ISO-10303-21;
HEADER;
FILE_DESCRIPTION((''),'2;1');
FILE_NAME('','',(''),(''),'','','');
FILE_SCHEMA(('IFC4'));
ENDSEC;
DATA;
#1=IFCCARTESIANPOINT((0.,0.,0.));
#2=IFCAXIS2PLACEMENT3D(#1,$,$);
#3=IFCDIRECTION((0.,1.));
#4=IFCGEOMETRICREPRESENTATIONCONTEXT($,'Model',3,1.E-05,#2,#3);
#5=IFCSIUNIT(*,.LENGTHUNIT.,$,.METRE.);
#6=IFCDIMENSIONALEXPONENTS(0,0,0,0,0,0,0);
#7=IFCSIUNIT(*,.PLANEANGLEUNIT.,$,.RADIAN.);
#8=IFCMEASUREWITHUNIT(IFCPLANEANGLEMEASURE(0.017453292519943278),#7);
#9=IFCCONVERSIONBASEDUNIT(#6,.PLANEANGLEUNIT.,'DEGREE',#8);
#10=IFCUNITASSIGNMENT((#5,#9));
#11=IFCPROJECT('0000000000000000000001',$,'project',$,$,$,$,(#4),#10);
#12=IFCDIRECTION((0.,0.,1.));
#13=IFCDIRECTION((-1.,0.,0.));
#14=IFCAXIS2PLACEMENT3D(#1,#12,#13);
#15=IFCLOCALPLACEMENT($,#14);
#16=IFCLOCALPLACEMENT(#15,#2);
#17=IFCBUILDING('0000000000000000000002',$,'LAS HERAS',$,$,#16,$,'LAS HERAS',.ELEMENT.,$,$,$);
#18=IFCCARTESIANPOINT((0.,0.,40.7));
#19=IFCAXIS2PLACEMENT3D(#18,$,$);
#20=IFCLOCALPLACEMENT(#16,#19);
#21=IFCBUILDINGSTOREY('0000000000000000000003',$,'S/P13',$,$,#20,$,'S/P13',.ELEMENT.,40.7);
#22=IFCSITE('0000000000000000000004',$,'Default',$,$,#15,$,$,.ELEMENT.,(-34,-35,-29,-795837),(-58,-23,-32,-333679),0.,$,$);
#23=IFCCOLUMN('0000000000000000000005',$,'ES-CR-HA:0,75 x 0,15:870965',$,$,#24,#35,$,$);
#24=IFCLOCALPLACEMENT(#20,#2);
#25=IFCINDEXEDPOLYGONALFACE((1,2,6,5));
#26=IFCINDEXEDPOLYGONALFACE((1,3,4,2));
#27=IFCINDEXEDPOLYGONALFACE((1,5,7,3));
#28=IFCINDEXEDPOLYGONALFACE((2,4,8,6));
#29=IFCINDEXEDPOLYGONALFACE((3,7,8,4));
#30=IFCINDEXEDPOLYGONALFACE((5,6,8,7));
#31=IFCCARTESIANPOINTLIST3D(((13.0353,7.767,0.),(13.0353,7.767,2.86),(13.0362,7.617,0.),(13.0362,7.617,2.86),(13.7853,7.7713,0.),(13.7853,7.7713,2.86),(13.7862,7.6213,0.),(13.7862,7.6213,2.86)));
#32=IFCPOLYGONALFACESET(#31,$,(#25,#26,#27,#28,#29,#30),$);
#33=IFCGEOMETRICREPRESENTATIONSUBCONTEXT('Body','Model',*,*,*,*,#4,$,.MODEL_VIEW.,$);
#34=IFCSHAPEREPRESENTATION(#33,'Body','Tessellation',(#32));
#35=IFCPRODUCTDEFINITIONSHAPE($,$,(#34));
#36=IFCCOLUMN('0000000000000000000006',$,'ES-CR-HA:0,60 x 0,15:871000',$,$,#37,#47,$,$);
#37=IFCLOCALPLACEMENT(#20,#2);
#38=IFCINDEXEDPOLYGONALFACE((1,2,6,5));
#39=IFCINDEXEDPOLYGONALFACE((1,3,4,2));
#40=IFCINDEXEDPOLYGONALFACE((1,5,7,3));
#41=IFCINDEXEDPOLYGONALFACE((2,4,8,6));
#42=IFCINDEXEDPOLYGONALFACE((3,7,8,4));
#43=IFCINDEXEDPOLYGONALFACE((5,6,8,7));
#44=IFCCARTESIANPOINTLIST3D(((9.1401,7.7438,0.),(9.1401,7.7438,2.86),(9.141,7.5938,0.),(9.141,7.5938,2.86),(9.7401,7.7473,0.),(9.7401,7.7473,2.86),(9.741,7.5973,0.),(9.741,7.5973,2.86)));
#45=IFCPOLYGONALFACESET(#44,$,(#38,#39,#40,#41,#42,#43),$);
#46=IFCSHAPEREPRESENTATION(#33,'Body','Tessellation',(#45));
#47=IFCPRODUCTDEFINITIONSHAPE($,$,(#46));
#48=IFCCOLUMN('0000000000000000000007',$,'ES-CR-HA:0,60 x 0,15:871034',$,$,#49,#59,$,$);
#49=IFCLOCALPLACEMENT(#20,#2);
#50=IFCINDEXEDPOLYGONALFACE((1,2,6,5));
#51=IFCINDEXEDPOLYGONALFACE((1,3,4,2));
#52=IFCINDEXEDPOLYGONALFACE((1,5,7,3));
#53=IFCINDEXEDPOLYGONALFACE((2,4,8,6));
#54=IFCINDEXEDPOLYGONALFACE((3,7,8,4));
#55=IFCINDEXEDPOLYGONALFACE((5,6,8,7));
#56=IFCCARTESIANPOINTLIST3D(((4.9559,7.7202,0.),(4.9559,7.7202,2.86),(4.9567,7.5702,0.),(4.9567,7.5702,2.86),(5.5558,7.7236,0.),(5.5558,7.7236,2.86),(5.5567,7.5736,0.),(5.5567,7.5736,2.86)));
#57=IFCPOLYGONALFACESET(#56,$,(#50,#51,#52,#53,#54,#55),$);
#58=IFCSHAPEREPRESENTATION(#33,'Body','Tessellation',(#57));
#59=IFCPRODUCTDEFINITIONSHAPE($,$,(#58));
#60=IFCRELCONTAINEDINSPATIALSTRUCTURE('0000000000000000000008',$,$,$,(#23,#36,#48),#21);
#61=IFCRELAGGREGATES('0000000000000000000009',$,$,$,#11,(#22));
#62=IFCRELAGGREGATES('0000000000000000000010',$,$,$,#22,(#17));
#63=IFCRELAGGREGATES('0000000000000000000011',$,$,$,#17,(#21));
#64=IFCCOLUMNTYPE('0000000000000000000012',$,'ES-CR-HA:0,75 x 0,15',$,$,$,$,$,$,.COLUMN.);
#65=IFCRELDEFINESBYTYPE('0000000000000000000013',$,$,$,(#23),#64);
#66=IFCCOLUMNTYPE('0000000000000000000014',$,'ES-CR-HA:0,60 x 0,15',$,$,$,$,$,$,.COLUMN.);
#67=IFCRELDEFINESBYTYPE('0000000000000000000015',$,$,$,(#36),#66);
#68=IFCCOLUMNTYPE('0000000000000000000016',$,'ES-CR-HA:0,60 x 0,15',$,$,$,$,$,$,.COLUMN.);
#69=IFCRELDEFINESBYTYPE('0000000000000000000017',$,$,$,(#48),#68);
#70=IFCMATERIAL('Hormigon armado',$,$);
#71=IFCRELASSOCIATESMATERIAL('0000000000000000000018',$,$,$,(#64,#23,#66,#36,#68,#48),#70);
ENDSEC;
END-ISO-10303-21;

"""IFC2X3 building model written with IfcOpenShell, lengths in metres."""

from ifc_helpers import new_model, entity, si_unit, converted_unit, direction, frame, frame_2d, origin, origin_2d_with_axis, place, context, subcontext, project, spatial, rectangle, extrude, source, transform, mapped, material, type_object, type_shapes, element, save


model = new_model("IFC2X3")

# Units and contexts
model_context = context("Model", 3, precision=1e-05, world=origin(), true_north=direction((0.0, 1.0)))
body_context = subcontext(model_context, "Body", "Model", "MODEL_VIEW")
ifc_project = project(units=[si_unit("LENGTHUNIT", "METRE"), converted_unit("PLANEANGLEUNIT", "DEGREE", entity("IfcPlaneAngleMeasure", 0.017453292519943278), si_unit("PLANEANGLEUNIT", "RADIAN"), dimensions=[0, 0, 0, 0, 0, 0, 0])], contexts=[model_context])

# Site, building, storey
site_placement = place(None, frame((0.0, 0.0, 0.0), z_axis=(0.0, 0.0, 1.0), x_axis=(-1.0, 0.0, 0.0)))
site = spatial("IfcSite", under=ifc_project, at=site_placement, Name="Default", CompositionType="ELEMENT", RefLatitude=(-34, -35, -29, -795837), RefLongitude=(-58, -23, -32, -333679), RefElevation=0.0)
building_placement = place(site_placement, origin())
building = spatial("IfcBuilding", under=site, at=building_placement, Name="LAS HERAS", LongName="LAS HERAS", CompositionType="ELEMENT")
storey_placement = place(building_placement, frame((0.0, 0.0, 40.7)))
storey = spatial("IfcBuildingStorey", under=building, at=storey_placement, Name="S/P13", LongName="S/P13", CompositionType="ELEMENT", Elevation=40.7)

# Columns
ifc_material = material(Name="Hormigon armado")
column_type_1 = type_object("IfcColumnType", Name="ES-CR-HA:0,75 x 0,15", PredefinedType="COLUMN", material=ifc_material)
shared_shape_1 = source(origin(), body_context, "Body", "SweptSolid", [
    extrude(rectangle(XDim=0.75, YDim=0.15, at=frame_2d((0.0, 0.0), x_axis=(1.0, 0.0))), frame((13.4108, 7.6942, 40.7), z_axis=(0.0, 0.0, 1.0), x_axis=(-0.999983, -0.005788, 0.0)), (0.0, 0.0, 1.0), 2.86),
])
type_shapes(column_type_1, [shared_shape_1])
column_1_placement = place(storey_placement, frame((0.0, 0.0, -40.7)))
element("IfcColumn", 1, at=column_1_placement, inside=storey, type_object=column_type_1, material=ifc_material, Name="ES-CR-HA:0,75 x 0,15:870965", context=body_context, shape_type="MappedRepresentation", body=[
    mapped(shared_shape_1, transform((0.0, 0.0, 0.0), scale=1.0)),
])
column_type_2 = type_object("IfcColumnType", Name="ES-CR-HA:0,60 x 0,15", PredefinedType="COLUMN", material=ifc_material)
shared_shape_2 = source(origin(), body_context, "Body", "SweptSolid", [
    extrude(rectangle(XDim=0.6, YDim=0.15, at=origin_2d_with_axis()), frame((9.4406, 7.6706, 40.7), z_axis=(0.0, 0.0, 1.0), x_axis=(-0.999983, -0.005788, 0.0)), (0.0, 0.0, 1.0), 2.86),
])
type_shapes(column_type_2, [shared_shape_2])
column_2_placement = place(storey_placement, frame((0.0, 0.0, -40.7)))
element("IfcColumn", 2, at=column_2_placement, inside=storey, type_object=column_type_2, material=ifc_material, Name="ES-CR-HA:0,60 x 0,15:871000", context=body_context, shape_type="MappedRepresentation", body=[
    mapped(shared_shape_2, transform((0.0, 0.0, 0.0), scale=1.0)),
])
column_type_3 = type_object("IfcColumnType", Name="ES-CR-HA:0,60 x 0,15", PredefinedType="COLUMN", material=ifc_material)
shared_shape_3 = source(origin(), body_context, "Body", "SweptSolid", [
    extrude(rectangle(XDim=0.6, YDim=0.15, at=origin_2d_with_axis()), frame((5.2563, 7.6469, 40.7), z_axis=(0.0, 0.0, 1.0), x_axis=(-0.999983, -0.005788, 0.0)), (0.0, 0.0, 1.0), 2.86),
])
type_shapes(column_type_3, [shared_shape_3])
column_3_placement = place(storey_placement, frame((0.0, 0.0, -40.7)))
element("IfcColumn", 3, at=column_3_placement, inside=storey, type_object=column_type_3, material=ifc_material, Name="ES-CR-HA:0,60 x 0,15:871034", context=body_context, shape_type="MappedRepresentation", body=[
    mapped(shared_shape_3, transform((0.0, 0.0, 0.0), scale=1.0)),
])

save(model, "model.ifc")
